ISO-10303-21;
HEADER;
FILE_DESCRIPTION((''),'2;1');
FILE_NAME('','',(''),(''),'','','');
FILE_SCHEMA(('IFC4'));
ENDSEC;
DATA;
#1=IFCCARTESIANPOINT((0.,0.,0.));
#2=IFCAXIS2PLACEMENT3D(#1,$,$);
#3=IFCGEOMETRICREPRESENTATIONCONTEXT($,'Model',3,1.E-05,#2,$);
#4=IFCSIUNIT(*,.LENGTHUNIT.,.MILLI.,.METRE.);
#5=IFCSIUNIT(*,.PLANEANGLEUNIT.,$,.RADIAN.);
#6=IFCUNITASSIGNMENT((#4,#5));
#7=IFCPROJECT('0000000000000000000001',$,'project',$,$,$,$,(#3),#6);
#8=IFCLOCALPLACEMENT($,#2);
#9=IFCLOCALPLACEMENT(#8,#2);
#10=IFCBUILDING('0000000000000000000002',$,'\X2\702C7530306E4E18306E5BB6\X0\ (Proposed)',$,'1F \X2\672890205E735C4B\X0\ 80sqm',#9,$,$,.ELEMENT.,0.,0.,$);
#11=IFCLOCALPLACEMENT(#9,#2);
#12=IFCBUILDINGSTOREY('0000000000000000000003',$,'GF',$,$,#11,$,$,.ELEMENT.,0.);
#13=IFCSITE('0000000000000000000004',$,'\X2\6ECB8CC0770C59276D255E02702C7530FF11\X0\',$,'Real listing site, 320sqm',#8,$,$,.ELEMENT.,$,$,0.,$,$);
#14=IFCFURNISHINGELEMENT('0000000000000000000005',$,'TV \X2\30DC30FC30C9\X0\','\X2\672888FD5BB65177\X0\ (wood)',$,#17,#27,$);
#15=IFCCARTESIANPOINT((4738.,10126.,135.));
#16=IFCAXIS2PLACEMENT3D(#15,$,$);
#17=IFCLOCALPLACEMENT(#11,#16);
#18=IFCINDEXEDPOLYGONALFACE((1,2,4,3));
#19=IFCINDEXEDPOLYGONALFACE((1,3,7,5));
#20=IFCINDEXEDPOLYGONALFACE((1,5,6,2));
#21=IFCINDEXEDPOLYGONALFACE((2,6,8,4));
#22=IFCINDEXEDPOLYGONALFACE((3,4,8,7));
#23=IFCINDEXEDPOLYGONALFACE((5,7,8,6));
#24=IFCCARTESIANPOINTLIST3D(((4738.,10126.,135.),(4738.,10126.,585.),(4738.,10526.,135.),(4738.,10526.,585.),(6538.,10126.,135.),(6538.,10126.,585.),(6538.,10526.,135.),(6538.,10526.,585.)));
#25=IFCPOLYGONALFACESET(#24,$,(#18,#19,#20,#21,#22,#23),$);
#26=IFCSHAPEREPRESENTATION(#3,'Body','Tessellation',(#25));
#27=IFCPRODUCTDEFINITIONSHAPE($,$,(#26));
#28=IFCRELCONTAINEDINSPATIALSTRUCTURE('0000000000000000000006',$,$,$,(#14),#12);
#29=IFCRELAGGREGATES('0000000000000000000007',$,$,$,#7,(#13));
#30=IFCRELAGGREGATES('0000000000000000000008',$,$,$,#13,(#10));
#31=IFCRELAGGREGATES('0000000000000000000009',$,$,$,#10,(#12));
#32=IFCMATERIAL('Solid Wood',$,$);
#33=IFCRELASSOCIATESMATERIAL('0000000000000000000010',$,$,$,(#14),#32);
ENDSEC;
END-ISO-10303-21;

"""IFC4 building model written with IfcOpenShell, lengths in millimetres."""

from ifc_helpers import new_model, si_unit, frame, frame_2d, origin, place, context, project, spatial, rectangle, extrude, material, element, save


model = new_model("IFC4")

# Units and contexts
model_context = context("Model", 3, precision=1e-05, world=origin())
ifc_project = project(units=[si_unit("LENGTHUNIT", "METRE", prefix="MILLI"), si_unit("PLANEANGLEUNIT", "RADIAN")], contexts=[model_context])

# Site, building, storey
site_placement = place(None, origin())
site = spatial("IfcSite", under=ifc_project, at=site_placement, Name="滋賀県大津市瀬田１", ObjectType="Real listing site, 320sqm", CompositionType="ELEMENT", RefElevation=0.0)
building_placement = place(site_placement, origin())
building = spatial("IfcBuilding", under=site, at=building_placement, Name="瀬田の丘の家 (Proposed)", ObjectType="1F 木造平屋 80sqm", CompositionType="ELEMENT", ElevationOfRefHeight=0.0, ElevationOfTerrain=0.0)
storey_placement = place(building_placement, origin())
storey = spatial("IfcBuildingStorey", under=building, at=storey_placement, Name="GF", CompositionType="ELEMENT", Elevation=0.0)

# Shared definitions
ifc_material_1 = material(Name="Solid Wood")

# Furnishing element
furnishing_1_placement = place(storey_placement, frame((4738.0, 10126.0, 135.0)))
element("IfcFurnishingElement", 1, at=furnishing_1_placement, inside=storey, material=ifc_material_1, Name="TV ボード", Description="木製家具 (wood)", context=model_context, shape_type="SweptSolid", body=[
    extrude(rectangle(XDim=1800.0, YDim=400.0, at=frame_2d((900.0, 200.0))), frame((4738.0, 10126.0, 135.0)), (0.0, 0.0, 1.0), 450.0),
])

save(model, "model.ifc")
